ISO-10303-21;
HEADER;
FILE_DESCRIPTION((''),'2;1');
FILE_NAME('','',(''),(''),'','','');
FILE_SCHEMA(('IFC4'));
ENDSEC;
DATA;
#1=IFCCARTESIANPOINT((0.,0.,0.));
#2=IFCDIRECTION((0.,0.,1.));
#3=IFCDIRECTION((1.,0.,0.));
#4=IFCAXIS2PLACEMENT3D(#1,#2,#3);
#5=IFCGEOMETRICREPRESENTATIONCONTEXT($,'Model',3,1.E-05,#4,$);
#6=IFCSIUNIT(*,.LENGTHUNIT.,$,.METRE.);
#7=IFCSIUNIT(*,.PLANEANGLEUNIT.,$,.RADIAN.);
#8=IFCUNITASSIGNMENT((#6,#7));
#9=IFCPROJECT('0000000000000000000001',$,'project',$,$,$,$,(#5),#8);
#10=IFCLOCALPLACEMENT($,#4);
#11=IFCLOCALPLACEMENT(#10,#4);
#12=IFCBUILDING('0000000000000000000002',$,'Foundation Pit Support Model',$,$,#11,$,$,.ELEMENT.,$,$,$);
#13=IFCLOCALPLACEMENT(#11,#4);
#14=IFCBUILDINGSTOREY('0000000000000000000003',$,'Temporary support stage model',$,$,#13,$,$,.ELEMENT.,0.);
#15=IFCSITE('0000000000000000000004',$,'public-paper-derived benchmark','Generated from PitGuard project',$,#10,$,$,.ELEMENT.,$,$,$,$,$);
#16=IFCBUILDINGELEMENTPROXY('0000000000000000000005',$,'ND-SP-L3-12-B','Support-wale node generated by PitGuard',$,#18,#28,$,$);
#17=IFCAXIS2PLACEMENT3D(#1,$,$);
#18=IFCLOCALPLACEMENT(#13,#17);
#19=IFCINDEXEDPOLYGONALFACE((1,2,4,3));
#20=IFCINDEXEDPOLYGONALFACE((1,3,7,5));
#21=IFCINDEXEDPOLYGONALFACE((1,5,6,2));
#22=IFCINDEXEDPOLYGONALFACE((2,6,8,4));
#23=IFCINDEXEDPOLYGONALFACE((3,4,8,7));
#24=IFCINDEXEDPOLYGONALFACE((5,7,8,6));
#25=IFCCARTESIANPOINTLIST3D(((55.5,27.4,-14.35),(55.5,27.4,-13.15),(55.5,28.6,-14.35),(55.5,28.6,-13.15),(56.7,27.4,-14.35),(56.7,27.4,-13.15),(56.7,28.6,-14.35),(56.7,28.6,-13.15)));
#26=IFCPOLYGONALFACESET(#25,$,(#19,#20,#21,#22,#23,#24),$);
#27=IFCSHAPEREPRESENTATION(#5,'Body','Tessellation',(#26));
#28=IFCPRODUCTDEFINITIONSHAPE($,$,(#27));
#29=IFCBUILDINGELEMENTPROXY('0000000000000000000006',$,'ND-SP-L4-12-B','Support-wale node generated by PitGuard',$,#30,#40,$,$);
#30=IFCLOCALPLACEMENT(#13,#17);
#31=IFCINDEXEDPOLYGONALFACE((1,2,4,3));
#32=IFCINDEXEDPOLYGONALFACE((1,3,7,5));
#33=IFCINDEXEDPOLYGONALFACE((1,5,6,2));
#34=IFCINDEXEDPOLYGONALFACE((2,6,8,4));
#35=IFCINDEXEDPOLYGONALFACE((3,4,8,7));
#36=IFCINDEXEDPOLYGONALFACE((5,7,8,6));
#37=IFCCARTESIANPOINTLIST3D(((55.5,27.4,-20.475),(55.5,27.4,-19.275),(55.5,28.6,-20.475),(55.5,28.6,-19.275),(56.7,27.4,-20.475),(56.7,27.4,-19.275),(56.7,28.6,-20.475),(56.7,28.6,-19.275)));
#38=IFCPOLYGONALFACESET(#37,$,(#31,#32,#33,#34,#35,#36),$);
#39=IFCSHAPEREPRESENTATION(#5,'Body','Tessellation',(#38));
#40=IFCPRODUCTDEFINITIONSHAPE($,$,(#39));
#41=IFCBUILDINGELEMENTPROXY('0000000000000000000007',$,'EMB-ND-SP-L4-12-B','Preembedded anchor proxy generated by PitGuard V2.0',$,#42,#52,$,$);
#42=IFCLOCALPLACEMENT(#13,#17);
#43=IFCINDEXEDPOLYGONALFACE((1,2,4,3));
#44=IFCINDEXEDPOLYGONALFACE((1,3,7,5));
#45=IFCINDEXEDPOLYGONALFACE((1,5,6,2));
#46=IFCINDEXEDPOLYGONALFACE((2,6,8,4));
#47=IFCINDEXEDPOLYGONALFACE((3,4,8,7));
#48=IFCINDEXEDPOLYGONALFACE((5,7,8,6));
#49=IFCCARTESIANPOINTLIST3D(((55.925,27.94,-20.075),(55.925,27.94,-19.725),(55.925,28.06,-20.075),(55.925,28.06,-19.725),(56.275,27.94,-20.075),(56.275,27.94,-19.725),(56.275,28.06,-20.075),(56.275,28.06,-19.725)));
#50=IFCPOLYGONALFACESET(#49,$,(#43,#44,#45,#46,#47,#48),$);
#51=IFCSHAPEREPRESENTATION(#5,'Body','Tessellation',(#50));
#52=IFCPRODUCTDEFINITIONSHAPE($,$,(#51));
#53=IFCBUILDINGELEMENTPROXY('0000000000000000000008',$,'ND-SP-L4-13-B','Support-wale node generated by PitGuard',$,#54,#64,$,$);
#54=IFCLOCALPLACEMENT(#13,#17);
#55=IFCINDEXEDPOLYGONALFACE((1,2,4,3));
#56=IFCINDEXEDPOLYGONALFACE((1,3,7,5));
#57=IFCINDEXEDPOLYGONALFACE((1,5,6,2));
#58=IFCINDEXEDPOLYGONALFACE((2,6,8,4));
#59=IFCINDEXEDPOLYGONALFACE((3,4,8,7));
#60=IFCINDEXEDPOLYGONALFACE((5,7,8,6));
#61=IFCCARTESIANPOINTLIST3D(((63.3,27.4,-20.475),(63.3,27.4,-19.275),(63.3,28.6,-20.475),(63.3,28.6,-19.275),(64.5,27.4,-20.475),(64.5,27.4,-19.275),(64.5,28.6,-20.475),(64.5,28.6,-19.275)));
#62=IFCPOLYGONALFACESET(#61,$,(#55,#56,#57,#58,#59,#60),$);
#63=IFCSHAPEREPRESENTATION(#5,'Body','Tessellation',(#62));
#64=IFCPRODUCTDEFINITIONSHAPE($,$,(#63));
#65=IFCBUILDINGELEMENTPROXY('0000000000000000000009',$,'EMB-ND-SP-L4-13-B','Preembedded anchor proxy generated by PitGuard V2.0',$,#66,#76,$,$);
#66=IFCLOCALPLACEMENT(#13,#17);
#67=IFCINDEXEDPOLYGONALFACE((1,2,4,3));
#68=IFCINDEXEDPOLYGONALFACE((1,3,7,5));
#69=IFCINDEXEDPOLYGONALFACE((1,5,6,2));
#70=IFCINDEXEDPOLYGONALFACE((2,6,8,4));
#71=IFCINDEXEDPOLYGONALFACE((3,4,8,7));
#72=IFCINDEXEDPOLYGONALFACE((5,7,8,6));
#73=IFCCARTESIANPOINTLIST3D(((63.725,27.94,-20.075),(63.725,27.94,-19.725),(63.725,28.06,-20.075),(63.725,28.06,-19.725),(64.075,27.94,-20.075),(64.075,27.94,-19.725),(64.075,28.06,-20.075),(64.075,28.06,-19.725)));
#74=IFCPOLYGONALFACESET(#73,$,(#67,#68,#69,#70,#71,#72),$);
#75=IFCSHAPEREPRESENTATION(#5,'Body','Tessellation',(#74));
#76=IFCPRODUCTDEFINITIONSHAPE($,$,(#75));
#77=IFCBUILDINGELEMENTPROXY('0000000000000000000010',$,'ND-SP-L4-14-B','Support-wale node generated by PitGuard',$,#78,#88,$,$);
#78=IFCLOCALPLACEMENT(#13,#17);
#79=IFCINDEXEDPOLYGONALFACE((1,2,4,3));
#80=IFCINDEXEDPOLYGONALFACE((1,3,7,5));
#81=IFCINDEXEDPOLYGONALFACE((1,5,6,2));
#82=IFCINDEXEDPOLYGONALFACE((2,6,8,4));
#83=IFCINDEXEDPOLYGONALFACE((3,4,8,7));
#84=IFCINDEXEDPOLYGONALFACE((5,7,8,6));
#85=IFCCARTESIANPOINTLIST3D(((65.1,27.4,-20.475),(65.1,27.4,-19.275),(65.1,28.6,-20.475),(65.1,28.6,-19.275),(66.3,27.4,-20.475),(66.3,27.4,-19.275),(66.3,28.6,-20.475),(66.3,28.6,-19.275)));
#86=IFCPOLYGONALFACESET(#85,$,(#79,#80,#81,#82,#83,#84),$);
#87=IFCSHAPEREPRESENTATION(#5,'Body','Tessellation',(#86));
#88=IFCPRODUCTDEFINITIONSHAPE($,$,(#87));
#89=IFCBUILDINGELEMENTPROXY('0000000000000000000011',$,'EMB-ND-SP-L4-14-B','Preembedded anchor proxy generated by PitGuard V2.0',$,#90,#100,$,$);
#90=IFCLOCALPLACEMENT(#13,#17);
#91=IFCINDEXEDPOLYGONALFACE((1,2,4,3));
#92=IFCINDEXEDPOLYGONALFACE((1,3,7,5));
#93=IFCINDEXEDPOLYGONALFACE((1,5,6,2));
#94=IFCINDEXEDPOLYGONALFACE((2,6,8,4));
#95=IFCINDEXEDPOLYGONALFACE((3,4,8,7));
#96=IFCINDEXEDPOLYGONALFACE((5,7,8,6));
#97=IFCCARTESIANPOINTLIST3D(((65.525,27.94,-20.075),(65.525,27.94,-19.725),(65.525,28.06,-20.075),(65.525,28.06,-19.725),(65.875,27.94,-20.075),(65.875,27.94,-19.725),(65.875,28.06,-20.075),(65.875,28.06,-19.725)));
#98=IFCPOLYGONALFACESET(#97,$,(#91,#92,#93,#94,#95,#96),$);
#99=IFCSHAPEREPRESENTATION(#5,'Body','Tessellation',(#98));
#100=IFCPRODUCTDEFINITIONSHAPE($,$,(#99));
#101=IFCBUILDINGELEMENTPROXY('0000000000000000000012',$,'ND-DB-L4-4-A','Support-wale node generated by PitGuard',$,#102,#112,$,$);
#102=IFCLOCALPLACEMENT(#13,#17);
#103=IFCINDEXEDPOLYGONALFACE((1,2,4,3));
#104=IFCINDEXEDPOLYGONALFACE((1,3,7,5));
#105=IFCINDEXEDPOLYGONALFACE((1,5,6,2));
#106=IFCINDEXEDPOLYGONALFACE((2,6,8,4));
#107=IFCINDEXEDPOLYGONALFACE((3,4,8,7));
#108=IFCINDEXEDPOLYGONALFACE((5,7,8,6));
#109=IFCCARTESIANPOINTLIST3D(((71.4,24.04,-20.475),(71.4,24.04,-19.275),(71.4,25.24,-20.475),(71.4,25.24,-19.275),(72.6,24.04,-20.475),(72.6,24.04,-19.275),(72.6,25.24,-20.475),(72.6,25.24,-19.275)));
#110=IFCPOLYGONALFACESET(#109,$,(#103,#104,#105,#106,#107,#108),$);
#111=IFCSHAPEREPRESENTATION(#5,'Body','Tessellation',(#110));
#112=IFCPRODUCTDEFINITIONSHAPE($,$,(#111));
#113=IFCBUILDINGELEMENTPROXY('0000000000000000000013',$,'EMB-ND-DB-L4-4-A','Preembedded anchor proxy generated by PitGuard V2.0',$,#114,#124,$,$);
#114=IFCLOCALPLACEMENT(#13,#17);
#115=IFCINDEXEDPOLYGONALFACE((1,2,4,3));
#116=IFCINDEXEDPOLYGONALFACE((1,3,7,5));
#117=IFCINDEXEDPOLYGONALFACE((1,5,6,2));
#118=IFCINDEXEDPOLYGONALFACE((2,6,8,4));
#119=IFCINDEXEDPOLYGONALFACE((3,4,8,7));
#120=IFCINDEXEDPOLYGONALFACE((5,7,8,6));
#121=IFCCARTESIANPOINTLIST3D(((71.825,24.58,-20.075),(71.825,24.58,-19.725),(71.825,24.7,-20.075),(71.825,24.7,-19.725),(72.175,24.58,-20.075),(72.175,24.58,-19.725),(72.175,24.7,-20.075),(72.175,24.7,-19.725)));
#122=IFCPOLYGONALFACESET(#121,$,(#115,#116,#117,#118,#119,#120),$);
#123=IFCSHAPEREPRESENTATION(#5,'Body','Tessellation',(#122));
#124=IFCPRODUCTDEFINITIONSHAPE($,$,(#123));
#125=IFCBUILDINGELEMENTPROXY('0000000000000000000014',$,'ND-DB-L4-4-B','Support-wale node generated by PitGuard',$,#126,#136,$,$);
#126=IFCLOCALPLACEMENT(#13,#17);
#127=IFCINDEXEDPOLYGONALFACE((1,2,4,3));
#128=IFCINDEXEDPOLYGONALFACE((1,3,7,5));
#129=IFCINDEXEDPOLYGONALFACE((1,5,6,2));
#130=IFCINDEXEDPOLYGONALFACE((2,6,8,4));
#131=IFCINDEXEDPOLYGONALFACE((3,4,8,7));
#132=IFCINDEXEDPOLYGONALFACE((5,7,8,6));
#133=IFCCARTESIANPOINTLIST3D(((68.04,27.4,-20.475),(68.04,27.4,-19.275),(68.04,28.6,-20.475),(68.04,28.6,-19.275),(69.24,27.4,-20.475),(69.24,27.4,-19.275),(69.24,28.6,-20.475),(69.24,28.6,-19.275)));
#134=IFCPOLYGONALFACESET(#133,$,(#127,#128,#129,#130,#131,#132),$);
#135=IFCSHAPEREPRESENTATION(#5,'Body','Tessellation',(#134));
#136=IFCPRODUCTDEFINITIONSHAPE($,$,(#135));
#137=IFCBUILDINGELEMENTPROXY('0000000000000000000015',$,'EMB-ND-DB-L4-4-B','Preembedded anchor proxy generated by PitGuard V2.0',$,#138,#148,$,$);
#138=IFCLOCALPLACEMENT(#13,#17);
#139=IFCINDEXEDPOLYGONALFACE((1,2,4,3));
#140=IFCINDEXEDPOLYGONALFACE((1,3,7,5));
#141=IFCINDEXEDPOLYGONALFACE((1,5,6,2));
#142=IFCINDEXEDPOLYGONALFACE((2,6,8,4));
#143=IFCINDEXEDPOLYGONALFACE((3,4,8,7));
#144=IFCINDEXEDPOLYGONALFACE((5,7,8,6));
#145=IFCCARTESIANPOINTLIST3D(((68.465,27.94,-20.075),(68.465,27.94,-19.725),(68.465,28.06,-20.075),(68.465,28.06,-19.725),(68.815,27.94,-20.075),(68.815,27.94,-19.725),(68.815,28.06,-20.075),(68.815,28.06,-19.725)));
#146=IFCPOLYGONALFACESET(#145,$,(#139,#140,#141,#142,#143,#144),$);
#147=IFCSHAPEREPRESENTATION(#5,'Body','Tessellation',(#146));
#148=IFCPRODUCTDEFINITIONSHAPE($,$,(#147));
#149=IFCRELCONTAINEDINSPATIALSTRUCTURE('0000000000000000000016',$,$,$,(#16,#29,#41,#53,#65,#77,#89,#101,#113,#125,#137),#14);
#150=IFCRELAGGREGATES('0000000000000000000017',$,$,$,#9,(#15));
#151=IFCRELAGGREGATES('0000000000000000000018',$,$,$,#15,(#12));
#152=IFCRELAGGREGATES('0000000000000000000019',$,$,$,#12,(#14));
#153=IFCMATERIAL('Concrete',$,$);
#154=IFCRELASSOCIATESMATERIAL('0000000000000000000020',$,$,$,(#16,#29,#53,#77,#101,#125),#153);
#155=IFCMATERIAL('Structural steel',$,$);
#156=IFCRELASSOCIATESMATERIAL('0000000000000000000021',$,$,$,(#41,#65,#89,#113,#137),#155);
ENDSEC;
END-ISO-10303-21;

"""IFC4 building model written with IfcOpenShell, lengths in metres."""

from ifc_helpers import new_model, si_unit, frame, origin_with_axes, origin_2d, place, context, project, spatial, rectangle, extrude, material, element, save


model = new_model("IFC4")

# Units and contexts
model_context = context("Model", 3, precision=1e-05, world=origin_with_axes())
ifc_project = project(units=[si_unit("LENGTHUNIT", "METRE"), si_unit("PLANEANGLEUNIT", "RADIAN")], contexts=[model_context])

# Site, building, storey
site_placement = place(None, origin_with_axes())
site = spatial("IfcSite", under=ifc_project, at=site_placement, Name="public-paper-derived benchmark", Description="Generated from PitGuard project", CompositionType="ELEMENT")
building_placement = place(site_placement, origin_with_axes())
building = spatial("IfcBuilding", under=site, at=building_placement, Name="Foundation Pit Support Model", CompositionType="ELEMENT")
storey_placement = place(building_placement, origin_with_axes())
storey = spatial("IfcBuildingStorey", under=building, at=storey_placement, Name="Temporary support stage model", CompositionType="ELEMENT", Elevation=0.0)

# Shared definitions
ifc_material_1 = material(Name="Concrete")

# Shared definitions
ifc_material_2 = material(Name="Structural steel")

# Building element proxies
for number, where, z_axis, x_axis, name in (
    (1, (56.1, 28.0, -14.35), (0.0, 0.0, 1.0), (1.0, 0.0, 0.0), "ND-SP-L3-12-B"),
    (2, (56.1, 28.0, -20.475), (0.0, 0.0, 1.0), (1.0, 0.0, 0.0), "ND-SP-L4-12-B"),
):
    element("IfcBuildingElementProxy", number, at=place(storey_placement, frame(where, z_axis=z_axis, x_axis=x_axis)), inside=storey, material=ifc_material_1, Name=name, Description="Support-wale node generated by PitGuard", context=model_context, shape_type="SweptSolid", body=[
        extrude(rectangle(XDim=1.2, YDim=1.2, at=origin_2d()), origin_with_axes(), (0.0, 0.0, 1.0), 1.2),
    ])
proxy_1_placement = place(storey_placement, frame((56.1, 28.0, -20.075), z_axis=(0.0, 0.0, 1.0), x_axis=(1.0, 0.0, 0.0)))
element("IfcBuildingElementProxy", 3, at=proxy_1_placement, inside=storey, material=ifc_material_2, Name="EMB-ND-SP-L4-12-B", Description="Preembedded anchor proxy generated by PitGuard V2.0", context=model_context, shape_type="SweptSolid", body=[
    extrude(rectangle(XDim=0.35, YDim=0.12, at=origin_2d()), origin_with_axes(), (0.0, 0.0, 1.0), 0.35),
])
proxy_2_placement = place(storey_placement, frame((63.9, 28.0, -20.475), z_axis=(0.0, 0.0, 1.0), x_axis=(1.0, 0.0, 0.0)))
element("IfcBuildingElementProxy", 4, at=proxy_2_placement, inside=storey, material=ifc_material_1, Name="ND-SP-L4-13-B", Description="Support-wale node generated by PitGuard", context=model_context, shape_type="SweptSolid", body=[
    extrude(rectangle(XDim=1.2, YDim=1.2, at=origin_2d()), origin_with_axes(), (0.0, 0.0, 1.0), 1.2),
])
proxy_3_placement = place(storey_placement, frame((63.9, 28.0, -20.075), z_axis=(0.0, 0.0, 1.0), x_axis=(1.0, 0.0, 0.0)))
element("IfcBuildingElementProxy", 5, at=proxy_3_placement, inside=storey, material=ifc_material_2, Name="EMB-ND-SP-L4-13-B", Description="Preembedded anchor proxy generated by PitGuard V2.0", context=model_context, shape_type="SweptSolid", body=[
    extrude(rectangle(XDim=0.35, YDim=0.12, at=origin_2d()), origin_with_axes(), (0.0, 0.0, 1.0), 0.35),
])
proxy_4_placement = place(storey_placement, frame((65.7, 28.0, -20.475), z_axis=(0.0, 0.0, 1.0), x_axis=(1.0, 0.0, 0.0)))
element("IfcBuildingElementProxy", 6, at=proxy_4_placement, inside=storey, material=ifc_material_1, Name="ND-SP-L4-14-B", Description="Support-wale node generated by PitGuard", context=model_context, shape_type="SweptSolid", body=[
    extrude(rectangle(XDim=1.2, YDim=1.2, at=origin_2d()), origin_with_axes(), (0.0, 0.0, 1.0), 1.2),
])
proxy_5_placement = place(storey_placement, frame((65.7, 28.0, -20.075), z_axis=(0.0, 0.0, 1.0), x_axis=(1.0, 0.0, 0.0)))
element("IfcBuildingElementProxy", 7, at=proxy_5_placement, inside=storey, material=ifc_material_2, Name="EMB-ND-SP-L4-14-B", Description="Preembedded anchor proxy generated by PitGuard V2.0", context=model_context, shape_type="SweptSolid", body=[
    extrude(rectangle(XDim=0.35, YDim=0.12, at=origin_2d()), origin_with_axes(), (0.0, 0.0, 1.0), 0.35),
])
proxy_6_placement = place(storey_placement, frame((72.0, 24.64, -20.475), z_axis=(0.0, 0.0, 1.0), x_axis=(1.0, 0.0, 0.0)))
element("IfcBuildingElementProxy", 8, at=proxy_6_placement, inside=storey, material=ifc_material_1, Name="ND-DB-L4-4-A", Description="Support-wale node generated by PitGuard", context=model_context, shape_type="SweptSolid", body=[
    extrude(rectangle(XDim=1.2, YDim=1.2, at=origin_2d()), origin_with_axes(), (0.0, 0.0, 1.0), 1.2),
])
proxy_7_placement = place(storey_placement, frame((72.0, 24.64, -20.075), z_axis=(0.0, 0.0, 1.0), x_axis=(1.0, 0.0, 0.0)))
element("IfcBuildingElementProxy", 9, at=proxy_7_placement, inside=storey, material=ifc_material_2, Name="EMB-ND-DB-L4-4-A", Description="Preembedded anchor proxy generated by PitGuard V2.0", context=model_context, shape_type="SweptSolid", body=[
    extrude(rectangle(XDim=0.35, YDim=0.12, at=origin_2d()), origin_with_axes(), (0.0, 0.0, 1.0), 0.35),
])
proxy_8_placement = place(storey_placement, frame((68.64, 28.0, -20.475), z_axis=(0.0, 0.0, 1.0), x_axis=(1.0, 0.0, 0.0)))
element("IfcBuildingElementProxy", 10, at=proxy_8_placement, inside=storey, material=ifc_material_1, Name="ND-DB-L4-4-B", Description="Support-wale node generated by PitGuard", context=model_context, shape_type="SweptSolid", body=[
    extrude(rectangle(XDim=1.2, YDim=1.2, at=origin_2d()), origin_with_axes(), (0.0, 0.0, 1.0), 1.2),
])
proxy_9_placement = place(storey_placement, frame((68.64, 28.0, -20.075), z_axis=(0.0, 0.0, 1.0), x_axis=(1.0, 0.0, 0.0)))
element("IfcBuildingElementProxy", 11, at=proxy_9_placement, inside=storey, material=ifc_material_2, Name="EMB-ND-DB-L4-4-B", Description="Preembedded anchor proxy generated by PitGuard V2.0", context=model_context, shape_type="SweptSolid", body=[
    extrude(rectangle(XDim=0.35, YDim=0.12, at=origin_2d()), origin_with_axes(), (0.0, 0.0, 1.0), 0.35),
])

save(model, "model.ifc")
